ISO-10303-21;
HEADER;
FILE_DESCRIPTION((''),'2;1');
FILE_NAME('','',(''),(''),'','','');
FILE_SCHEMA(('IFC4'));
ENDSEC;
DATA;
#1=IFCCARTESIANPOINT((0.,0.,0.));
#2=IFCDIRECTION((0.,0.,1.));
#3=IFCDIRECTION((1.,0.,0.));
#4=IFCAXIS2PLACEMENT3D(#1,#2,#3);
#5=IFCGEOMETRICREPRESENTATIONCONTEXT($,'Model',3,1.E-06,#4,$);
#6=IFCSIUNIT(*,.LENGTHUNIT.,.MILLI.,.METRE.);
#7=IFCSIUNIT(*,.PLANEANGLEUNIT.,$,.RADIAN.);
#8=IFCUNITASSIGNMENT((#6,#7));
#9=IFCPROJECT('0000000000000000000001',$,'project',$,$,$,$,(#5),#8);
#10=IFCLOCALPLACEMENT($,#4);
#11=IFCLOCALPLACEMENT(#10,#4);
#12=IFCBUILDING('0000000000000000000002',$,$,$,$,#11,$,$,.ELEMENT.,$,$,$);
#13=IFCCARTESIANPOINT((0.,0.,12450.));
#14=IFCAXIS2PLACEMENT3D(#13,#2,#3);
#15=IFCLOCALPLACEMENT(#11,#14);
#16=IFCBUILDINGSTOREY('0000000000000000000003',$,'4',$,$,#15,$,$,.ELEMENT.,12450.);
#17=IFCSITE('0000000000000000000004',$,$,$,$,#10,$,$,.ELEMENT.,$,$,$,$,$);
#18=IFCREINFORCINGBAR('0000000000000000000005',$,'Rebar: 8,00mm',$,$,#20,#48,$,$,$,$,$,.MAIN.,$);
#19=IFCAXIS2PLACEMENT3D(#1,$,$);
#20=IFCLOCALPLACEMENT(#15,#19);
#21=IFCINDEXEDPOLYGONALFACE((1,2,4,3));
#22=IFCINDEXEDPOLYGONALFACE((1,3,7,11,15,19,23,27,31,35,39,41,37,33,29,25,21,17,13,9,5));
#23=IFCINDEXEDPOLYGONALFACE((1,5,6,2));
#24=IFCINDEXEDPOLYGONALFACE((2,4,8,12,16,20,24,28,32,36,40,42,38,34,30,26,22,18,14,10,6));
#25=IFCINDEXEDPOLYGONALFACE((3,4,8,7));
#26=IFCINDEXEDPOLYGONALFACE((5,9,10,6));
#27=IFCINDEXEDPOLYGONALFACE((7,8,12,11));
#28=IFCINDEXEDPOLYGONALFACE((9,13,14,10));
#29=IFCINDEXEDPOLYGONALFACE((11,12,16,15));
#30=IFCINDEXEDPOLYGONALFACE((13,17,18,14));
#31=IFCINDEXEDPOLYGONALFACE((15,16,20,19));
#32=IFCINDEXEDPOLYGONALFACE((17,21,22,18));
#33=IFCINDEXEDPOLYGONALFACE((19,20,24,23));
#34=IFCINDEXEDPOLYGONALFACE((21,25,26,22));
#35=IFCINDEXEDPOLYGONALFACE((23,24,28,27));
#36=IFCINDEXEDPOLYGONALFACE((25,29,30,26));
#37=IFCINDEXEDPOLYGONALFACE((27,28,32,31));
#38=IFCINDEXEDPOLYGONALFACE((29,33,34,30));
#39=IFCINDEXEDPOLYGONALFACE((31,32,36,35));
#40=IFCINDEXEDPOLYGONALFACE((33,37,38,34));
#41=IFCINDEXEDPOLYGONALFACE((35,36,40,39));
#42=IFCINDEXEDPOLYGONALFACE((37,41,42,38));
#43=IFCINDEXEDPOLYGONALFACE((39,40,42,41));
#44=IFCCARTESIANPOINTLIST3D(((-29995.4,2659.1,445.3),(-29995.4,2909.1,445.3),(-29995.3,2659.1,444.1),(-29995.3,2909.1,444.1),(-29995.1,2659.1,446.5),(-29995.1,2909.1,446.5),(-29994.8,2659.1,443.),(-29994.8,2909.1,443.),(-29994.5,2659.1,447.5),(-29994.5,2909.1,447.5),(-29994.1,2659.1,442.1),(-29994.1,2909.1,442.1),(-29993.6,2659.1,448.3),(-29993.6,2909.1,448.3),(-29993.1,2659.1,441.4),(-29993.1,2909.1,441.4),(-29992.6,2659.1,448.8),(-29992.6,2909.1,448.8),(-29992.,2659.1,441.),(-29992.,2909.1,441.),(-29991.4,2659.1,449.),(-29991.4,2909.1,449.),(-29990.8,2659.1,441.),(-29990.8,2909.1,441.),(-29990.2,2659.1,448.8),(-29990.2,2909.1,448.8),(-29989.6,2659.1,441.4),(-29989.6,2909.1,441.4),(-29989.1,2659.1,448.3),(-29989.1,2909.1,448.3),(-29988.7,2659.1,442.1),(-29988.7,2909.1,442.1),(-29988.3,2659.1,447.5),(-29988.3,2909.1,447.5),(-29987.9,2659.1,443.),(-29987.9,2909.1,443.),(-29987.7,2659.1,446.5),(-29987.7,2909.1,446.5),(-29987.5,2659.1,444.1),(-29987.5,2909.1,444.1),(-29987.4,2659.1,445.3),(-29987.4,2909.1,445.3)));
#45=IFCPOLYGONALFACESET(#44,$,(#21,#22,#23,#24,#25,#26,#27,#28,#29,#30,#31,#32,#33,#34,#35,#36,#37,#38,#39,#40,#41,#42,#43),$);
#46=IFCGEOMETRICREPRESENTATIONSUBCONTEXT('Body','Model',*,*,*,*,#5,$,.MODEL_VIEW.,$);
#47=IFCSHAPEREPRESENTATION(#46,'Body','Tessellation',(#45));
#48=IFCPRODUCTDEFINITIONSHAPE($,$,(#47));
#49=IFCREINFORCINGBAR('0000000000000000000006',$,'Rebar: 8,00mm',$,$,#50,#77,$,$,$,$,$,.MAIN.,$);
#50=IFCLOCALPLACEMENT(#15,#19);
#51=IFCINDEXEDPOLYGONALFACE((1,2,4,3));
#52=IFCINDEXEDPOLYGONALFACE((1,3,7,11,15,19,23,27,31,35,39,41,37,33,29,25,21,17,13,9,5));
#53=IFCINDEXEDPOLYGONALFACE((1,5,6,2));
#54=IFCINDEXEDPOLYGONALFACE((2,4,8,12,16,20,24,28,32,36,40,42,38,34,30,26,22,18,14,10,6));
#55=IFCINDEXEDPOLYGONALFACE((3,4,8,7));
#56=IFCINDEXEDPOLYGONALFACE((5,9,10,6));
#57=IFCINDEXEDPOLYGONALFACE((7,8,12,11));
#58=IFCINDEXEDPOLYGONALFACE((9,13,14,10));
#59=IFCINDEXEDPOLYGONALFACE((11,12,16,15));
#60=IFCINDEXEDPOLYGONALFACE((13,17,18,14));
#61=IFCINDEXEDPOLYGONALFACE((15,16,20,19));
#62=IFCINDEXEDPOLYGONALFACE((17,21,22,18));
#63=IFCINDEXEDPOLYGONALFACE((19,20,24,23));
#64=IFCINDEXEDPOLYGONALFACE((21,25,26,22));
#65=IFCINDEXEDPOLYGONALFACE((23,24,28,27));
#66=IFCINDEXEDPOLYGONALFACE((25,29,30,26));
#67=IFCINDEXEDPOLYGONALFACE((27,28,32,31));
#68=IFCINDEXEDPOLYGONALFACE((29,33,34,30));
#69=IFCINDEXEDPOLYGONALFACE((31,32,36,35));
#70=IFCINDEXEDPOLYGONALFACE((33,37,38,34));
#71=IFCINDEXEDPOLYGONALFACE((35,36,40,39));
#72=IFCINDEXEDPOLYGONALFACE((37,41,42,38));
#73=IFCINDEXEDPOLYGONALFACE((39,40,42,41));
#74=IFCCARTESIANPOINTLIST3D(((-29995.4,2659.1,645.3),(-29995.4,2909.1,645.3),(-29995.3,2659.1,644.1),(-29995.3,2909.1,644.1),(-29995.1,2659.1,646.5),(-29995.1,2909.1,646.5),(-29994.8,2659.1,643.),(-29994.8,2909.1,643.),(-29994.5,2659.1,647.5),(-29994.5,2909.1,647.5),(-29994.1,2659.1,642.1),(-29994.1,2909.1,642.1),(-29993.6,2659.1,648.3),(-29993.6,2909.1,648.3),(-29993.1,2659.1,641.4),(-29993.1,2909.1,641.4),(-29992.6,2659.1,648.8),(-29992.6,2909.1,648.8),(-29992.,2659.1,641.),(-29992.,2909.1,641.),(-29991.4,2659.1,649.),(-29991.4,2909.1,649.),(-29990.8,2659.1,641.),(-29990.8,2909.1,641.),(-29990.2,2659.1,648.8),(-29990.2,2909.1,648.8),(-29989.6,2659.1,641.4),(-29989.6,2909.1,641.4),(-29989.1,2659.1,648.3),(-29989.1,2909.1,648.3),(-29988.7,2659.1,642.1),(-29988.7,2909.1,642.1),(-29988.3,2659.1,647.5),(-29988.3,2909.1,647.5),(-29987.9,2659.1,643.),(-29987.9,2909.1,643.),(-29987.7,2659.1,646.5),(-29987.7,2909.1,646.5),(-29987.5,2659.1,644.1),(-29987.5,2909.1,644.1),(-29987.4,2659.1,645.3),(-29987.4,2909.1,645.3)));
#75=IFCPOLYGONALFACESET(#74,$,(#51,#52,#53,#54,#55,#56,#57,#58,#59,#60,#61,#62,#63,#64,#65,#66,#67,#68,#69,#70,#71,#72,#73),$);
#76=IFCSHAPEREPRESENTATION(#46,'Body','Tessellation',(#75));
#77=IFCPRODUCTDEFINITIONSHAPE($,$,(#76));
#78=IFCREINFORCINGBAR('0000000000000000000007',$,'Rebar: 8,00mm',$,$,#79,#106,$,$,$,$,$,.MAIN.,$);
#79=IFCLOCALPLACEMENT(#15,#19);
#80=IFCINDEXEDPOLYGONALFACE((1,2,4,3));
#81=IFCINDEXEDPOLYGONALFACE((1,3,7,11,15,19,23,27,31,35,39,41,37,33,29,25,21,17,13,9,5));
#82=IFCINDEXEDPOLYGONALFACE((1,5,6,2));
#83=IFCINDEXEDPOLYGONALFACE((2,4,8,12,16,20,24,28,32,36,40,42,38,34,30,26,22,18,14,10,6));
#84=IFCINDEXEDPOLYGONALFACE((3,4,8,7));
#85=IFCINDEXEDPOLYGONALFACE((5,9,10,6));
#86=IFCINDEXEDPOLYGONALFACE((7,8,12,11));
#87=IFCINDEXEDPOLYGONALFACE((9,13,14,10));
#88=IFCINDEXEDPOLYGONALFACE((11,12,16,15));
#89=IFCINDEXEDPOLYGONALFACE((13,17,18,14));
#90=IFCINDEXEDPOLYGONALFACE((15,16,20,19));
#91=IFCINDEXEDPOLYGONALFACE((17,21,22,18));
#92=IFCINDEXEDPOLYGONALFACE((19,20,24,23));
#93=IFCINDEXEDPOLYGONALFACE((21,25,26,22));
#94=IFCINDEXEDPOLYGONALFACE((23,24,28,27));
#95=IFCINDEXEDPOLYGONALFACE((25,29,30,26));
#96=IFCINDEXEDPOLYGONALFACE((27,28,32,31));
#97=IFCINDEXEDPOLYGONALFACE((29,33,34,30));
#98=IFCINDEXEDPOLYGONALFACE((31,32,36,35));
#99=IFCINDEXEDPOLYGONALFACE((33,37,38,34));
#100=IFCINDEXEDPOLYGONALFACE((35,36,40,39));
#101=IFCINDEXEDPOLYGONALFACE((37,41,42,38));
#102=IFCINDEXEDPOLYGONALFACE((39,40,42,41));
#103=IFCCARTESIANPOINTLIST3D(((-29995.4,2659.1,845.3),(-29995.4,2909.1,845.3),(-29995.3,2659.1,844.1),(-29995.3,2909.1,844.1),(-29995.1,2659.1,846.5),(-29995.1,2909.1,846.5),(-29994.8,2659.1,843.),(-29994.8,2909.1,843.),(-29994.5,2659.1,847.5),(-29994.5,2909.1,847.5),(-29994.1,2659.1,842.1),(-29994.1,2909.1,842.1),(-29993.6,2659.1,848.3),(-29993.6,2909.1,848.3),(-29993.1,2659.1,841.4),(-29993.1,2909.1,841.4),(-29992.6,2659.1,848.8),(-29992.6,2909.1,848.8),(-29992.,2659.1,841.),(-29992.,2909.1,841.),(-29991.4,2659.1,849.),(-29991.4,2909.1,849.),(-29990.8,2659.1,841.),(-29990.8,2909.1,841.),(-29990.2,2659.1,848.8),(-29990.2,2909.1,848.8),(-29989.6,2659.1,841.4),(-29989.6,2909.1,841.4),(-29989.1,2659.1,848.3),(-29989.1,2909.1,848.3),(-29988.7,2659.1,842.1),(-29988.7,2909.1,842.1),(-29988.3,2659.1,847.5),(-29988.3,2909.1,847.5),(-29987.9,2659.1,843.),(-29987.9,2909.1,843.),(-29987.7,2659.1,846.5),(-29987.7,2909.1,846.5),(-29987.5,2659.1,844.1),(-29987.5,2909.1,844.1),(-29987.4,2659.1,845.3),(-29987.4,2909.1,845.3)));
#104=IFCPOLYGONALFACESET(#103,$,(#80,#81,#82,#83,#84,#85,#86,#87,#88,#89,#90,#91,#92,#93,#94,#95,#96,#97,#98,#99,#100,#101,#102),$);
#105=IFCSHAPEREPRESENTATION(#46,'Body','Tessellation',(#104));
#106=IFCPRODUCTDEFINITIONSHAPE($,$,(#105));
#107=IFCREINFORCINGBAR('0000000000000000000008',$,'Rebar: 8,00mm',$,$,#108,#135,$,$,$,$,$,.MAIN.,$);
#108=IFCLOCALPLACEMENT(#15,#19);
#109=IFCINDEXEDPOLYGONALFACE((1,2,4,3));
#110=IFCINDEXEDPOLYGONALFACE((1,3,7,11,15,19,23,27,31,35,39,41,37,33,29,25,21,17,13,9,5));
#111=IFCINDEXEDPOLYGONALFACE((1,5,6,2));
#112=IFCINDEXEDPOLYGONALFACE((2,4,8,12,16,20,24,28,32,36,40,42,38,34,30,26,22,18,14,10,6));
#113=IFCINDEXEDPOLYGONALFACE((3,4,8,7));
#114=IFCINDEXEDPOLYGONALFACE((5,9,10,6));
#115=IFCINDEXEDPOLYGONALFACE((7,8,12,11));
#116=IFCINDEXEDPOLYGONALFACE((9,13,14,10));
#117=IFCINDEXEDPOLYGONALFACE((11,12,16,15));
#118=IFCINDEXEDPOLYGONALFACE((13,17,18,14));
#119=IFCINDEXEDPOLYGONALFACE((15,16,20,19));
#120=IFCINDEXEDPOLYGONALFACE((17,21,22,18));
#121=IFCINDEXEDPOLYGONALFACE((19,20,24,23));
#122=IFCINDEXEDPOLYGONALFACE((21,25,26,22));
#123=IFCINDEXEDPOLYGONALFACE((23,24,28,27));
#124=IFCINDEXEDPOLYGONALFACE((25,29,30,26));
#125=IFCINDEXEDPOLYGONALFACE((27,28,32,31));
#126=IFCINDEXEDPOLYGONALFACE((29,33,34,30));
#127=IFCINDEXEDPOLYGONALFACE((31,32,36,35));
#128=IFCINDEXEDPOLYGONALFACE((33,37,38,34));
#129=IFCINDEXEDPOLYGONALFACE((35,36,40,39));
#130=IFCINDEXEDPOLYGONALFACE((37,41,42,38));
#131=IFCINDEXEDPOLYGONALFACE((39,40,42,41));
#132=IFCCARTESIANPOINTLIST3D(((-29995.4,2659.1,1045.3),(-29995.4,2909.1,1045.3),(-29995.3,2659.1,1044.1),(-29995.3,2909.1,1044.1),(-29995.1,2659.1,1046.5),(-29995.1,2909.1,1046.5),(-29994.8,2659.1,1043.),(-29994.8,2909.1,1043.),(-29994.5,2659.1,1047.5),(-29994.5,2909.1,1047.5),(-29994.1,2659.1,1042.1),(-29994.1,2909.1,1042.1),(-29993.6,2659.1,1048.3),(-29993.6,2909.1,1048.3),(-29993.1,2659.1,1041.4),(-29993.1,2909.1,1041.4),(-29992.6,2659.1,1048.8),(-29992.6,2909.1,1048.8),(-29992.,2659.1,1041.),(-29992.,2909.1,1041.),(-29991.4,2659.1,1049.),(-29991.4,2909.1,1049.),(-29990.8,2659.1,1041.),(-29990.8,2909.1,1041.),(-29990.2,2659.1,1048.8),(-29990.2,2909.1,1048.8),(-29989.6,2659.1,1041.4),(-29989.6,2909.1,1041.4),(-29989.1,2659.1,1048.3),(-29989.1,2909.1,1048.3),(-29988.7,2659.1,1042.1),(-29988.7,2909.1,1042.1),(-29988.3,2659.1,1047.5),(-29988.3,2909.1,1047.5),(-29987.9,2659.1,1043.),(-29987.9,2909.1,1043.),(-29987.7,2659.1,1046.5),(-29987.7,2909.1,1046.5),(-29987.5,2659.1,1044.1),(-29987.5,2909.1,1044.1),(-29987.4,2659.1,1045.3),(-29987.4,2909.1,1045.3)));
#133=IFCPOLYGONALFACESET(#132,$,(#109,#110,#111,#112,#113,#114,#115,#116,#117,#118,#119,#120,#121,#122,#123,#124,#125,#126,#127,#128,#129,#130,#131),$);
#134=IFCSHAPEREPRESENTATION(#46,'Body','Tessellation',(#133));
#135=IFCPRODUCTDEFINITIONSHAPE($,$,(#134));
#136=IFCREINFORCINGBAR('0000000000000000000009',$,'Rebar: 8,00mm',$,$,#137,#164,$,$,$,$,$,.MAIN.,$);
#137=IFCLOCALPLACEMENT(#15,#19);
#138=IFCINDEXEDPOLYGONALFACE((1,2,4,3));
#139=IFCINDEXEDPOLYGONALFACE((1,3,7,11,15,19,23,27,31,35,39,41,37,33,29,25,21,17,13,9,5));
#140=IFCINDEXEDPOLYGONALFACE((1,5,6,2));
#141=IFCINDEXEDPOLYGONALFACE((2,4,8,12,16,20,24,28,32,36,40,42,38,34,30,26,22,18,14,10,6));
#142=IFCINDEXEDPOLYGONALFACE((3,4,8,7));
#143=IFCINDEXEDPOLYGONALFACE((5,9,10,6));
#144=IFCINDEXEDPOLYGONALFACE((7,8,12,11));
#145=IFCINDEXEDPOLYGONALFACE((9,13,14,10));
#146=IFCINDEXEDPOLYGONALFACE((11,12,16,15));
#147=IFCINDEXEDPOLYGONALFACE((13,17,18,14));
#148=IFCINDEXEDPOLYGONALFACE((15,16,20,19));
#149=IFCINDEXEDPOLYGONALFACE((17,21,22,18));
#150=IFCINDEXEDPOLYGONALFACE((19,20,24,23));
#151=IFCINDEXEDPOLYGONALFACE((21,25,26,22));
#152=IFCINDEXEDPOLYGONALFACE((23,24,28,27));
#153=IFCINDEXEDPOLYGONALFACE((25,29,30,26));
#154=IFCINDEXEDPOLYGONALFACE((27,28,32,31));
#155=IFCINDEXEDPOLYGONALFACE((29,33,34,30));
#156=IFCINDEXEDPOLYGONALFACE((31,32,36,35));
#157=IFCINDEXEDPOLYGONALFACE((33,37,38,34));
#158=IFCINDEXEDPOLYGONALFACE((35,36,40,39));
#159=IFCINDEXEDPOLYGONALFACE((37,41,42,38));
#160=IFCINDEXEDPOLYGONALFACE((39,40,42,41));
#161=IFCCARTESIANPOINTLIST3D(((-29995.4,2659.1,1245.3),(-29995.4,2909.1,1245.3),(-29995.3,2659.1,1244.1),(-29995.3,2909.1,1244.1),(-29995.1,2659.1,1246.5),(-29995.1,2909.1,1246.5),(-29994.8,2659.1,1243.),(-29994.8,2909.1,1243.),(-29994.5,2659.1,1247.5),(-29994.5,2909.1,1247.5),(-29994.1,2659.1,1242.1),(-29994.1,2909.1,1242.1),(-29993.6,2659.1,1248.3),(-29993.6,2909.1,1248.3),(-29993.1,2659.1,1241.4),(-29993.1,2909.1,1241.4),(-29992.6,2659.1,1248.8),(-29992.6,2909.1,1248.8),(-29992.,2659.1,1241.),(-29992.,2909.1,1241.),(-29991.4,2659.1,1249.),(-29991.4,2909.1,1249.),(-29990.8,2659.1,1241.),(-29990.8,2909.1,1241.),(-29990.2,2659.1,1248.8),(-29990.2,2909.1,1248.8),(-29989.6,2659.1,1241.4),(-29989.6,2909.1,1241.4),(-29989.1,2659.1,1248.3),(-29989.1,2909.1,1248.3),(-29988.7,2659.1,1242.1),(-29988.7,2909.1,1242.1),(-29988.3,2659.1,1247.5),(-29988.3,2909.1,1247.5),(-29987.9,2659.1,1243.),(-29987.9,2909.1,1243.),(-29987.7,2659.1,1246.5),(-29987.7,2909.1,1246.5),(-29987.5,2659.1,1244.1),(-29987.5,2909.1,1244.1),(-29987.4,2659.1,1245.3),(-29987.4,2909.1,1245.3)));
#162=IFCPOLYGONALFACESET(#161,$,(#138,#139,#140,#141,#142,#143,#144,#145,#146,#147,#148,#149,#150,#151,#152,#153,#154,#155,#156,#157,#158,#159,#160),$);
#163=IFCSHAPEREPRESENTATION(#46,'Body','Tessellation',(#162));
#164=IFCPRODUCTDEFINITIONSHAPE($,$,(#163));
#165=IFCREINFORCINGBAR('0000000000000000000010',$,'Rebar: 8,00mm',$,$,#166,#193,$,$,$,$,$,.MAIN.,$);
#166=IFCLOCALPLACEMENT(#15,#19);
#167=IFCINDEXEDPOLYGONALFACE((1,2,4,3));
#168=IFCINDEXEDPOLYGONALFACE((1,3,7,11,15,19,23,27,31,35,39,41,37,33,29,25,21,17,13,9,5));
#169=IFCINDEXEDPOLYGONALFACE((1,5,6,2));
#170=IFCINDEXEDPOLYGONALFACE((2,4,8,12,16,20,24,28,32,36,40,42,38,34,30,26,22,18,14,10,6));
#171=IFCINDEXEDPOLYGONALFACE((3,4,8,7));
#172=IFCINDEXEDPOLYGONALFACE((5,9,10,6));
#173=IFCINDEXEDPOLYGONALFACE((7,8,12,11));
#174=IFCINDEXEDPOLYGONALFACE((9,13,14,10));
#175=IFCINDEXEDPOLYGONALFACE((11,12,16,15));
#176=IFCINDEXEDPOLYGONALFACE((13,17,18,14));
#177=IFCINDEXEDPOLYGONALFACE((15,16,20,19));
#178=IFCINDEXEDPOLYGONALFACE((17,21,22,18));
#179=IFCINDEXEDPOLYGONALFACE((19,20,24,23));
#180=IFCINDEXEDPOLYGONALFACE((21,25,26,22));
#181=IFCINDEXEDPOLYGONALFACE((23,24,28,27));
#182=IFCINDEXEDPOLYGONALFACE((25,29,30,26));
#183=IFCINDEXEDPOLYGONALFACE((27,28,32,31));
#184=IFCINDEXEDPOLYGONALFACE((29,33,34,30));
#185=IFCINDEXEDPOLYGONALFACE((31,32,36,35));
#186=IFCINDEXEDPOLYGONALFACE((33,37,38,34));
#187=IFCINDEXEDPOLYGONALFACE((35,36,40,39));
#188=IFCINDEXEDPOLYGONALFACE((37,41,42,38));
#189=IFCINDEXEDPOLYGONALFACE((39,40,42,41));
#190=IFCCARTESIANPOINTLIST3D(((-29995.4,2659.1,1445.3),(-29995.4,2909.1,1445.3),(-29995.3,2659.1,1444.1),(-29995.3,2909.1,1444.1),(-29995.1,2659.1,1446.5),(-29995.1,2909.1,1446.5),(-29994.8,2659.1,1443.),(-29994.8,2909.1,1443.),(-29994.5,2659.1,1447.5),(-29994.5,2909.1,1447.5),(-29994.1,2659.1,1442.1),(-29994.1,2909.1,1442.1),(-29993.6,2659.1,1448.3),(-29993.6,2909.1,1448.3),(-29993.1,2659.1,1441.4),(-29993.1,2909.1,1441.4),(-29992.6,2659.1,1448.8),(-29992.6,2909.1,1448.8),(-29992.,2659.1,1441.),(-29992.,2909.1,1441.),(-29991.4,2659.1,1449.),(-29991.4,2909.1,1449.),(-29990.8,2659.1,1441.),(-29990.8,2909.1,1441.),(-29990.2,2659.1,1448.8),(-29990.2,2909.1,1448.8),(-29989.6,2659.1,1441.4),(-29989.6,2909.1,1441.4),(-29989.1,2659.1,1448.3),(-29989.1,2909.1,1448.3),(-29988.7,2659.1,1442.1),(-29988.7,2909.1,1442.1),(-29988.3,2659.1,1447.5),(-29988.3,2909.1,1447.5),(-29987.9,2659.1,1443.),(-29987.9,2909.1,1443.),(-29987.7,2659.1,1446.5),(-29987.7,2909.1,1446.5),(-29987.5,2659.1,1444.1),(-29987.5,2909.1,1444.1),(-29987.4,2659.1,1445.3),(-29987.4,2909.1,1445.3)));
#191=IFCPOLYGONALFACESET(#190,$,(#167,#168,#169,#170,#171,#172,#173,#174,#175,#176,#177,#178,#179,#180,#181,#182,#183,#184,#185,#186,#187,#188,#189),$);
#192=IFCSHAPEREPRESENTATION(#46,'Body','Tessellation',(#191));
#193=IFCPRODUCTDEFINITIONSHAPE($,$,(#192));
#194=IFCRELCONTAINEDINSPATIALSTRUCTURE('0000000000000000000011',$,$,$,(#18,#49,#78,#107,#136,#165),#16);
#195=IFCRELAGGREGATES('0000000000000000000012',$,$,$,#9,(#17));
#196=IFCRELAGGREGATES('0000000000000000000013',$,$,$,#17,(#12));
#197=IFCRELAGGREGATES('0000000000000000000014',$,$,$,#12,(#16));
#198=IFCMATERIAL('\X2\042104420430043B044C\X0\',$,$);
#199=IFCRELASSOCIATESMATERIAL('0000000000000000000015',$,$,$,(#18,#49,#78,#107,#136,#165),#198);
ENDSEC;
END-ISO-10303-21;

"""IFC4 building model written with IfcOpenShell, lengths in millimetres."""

from ifc_helpers import new_model, entity, si_unit, frame, origin_with_axes, place, context, subcontext, project, spatial, source, transform, mapped, material, element, save


model = new_model("IFC4")

# Units and contexts
model_context = context("Model", 3, precision=1e-06, world=origin_with_axes())
body_context = subcontext(model_context, "Body", "Model", "MODEL_VIEW")
ifc_project = project(units=[si_unit("LENGTHUNIT", "METRE", prefix="MILLI"), si_unit("PLANEANGLEUNIT", "RADIAN")], contexts=[model_context])

# Site, building, storey
site_placement = place(None, origin_with_axes())
site = spatial("IfcSite", under=ifc_project, at=site_placement, CompositionType="ELEMENT")
building_placement = place(site_placement, origin_with_axes())
building = spatial("IfcBuilding", under=site, at=building_placement, CompositionType="ELEMENT")
storey_placement = place(building_placement, frame((0.0, 0.0, 12450.0), z_axis=(0.0, 0.0, 1.0), x_axis=(1.0, 0.0, 0.0)))
storey = spatial("IfcBuildingStorey", under=building, at=storey_placement, Name="4", CompositionType="ELEMENT", Elevation=12450.0)

# Reinforcing bars
ifc_material = material(Name="Сталь")
shared_shape_1 = source(origin_with_axes(), body_context, "Body", "AdvancedSweptSolid", [
    entity("IfcSweptDiskSolid", entity("IfcIndexedPolyCurve", entity("IfcCartesianPointList3D", [[0.0, 0.0, 0.0], [250.0, 0.0, 0.0]]), [entity("IfcLineIndex", [1, 2])]), 4.0),
])
reinforcing_bar_1_placement = place(storey_placement, origin_with_axes())
element("IfcReinforcingBar", 1, at=reinforcing_bar_1_placement, inside=storey, material=ifc_material, Name="Rebar: 8,00mm", PredefinedType="MAIN", context=body_context, shape_type="MappedRepresentation", body=[
    mapped(shared_shape_1, transform((-29991.4, 2909.1, 445.0), x_axis=(0.0, -1.0, 0.0), y_axis=(1.0, 0.0, 0.0), z_axis=(0.0, 0.0, 1.0), scale=1.0)),
])
reinforcing_bar_2_placement = place(storey_placement, origin_with_axes())
element("IfcReinforcingBar", 2, at=reinforcing_bar_2_placement, inside=storey, material=ifc_material, Name="Rebar: 8,00mm", PredefinedType="MAIN", context=body_context, shape_type="MappedRepresentation", body=[
    mapped(shared_shape_1, transform((-29991.4, 2909.1, 645.0), x_axis=(0.0, -1.0, 0.0), y_axis=(1.0, 0.0, 0.0), z_axis=(0.0, 0.0, 1.0), scale=1.0)),
])
reinforcing_bar_3_placement = place(storey_placement, origin_with_axes())
element("IfcReinforcingBar", 3, at=reinforcing_bar_3_placement, inside=storey, material=ifc_material, Name="Rebar: 8,00mm", PredefinedType="MAIN", context=body_context, shape_type="MappedRepresentation", body=[
    mapped(shared_shape_1, transform((-29991.4, 2909.1, 845.0), x_axis=(0.0, -1.0, 0.0), y_axis=(1.0, 0.0, 0.0), z_axis=(0.0, 0.0, 1.0), scale=1.0)),
])
reinforcing_bar_4_placement = place(storey_placement, origin_with_axes())
element("IfcReinforcingBar", 4, at=reinforcing_bar_4_placement, inside=storey, material=ifc_material, Name="Rebar: 8,00mm", PredefinedType="MAIN", context=body_context, shape_type="MappedRepresentation", body=[
    mapped(shared_shape_1, transform((-29991.4, 2909.1, 1045.0), x_axis=(0.0, -1.0, 0.0), y_axis=(1.0, 0.0, 0.0), z_axis=(0.0, 0.0, 1.0), scale=1.0)),
])
reinforcing_bar_5_placement = place(storey_placement, origin_with_axes())
element("IfcReinforcingBar", 5, at=reinforcing_bar_5_placement, inside=storey, material=ifc_material, Name="Rebar: 8,00mm", PredefinedType="MAIN", context=body_context, shape_type="MappedRepresentation", body=[
    mapped(shared_shape_1, transform((-29991.4, 2909.1, 1245.0), x_axis=(0.0, -1.0, 0.0), y_axis=(1.0, 0.0, 0.0), z_axis=(0.0, 0.0, 1.0), scale=1.0)),
])
reinforcing_bar_6_placement = place(storey_placement, origin_with_axes())
element("IfcReinforcingBar", 6, at=reinforcing_bar_6_placement, inside=storey, material=ifc_material, Name="Rebar: 8,00mm", PredefinedType="MAIN", context=body_context, shape_type="MappedRepresentation", body=[
    mapped(shared_shape_1, transform((-29991.4, 2909.1, 1445.0), x_axis=(0.0, -1.0, 0.0), y_axis=(1.0, 0.0, 0.0), z_axis=(0.0, 0.0, 1.0), scale=1.0)),
])

save(model, "model.ifc")
